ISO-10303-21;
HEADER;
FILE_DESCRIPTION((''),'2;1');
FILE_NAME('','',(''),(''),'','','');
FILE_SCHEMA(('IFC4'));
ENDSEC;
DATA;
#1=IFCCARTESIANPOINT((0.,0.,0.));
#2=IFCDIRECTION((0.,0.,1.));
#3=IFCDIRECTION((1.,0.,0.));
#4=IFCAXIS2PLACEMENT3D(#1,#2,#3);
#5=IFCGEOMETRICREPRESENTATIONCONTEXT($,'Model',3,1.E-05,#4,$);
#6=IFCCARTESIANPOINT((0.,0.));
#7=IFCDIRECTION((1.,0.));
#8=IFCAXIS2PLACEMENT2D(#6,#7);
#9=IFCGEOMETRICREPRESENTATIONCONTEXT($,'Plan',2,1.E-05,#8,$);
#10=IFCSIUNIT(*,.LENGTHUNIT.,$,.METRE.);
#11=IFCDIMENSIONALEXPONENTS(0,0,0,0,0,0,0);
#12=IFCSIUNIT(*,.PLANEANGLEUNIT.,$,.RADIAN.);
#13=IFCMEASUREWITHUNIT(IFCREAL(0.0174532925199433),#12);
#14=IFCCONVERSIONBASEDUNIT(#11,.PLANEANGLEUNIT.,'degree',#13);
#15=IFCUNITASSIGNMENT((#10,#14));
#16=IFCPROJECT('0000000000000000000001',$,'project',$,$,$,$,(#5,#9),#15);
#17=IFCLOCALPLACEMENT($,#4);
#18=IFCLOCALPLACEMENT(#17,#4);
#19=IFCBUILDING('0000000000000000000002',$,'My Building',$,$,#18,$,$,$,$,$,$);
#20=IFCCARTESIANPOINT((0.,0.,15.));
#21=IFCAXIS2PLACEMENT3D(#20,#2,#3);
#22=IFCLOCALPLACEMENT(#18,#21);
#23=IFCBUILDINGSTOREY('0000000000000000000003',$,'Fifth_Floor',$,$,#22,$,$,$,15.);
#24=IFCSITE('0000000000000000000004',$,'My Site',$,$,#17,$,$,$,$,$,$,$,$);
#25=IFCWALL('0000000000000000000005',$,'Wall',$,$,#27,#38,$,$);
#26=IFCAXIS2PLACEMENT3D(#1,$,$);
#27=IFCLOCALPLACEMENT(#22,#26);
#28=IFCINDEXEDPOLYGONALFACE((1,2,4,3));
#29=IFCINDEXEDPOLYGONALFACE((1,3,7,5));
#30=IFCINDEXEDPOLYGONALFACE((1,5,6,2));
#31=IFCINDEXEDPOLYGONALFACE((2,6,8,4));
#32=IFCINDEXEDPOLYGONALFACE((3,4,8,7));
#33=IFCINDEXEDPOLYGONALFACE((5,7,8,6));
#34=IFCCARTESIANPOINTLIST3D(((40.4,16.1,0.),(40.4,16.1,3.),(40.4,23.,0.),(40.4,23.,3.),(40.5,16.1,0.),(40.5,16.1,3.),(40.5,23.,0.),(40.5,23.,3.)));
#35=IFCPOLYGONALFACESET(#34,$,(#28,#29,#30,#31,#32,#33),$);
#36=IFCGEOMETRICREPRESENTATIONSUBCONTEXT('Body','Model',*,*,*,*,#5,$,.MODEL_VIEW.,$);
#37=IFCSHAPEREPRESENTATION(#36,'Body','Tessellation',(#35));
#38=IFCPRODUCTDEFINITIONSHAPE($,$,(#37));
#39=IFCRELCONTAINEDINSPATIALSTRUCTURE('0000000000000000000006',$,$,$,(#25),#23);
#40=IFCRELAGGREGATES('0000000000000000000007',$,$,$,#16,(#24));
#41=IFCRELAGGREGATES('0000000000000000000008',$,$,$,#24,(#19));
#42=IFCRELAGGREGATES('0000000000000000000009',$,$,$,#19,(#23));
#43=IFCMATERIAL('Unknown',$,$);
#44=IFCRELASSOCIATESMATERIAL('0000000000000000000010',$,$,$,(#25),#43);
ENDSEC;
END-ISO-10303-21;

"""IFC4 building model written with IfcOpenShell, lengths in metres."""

from ifc_helpers import new_model, entity, si_unit, converted_unit, frame, frame_2d, origin, origin_with_axes, origin_2d_with_axis, place, context, subcontext, project, spatial, rectangle, extrude, material, element, save


model = new_model("IFC4")

# Units and contexts
model_context = context("Model", 3, precision=1e-05, world=origin_with_axes())
plan_context = context("Plan", 2, precision=1e-05, world=origin_2d_with_axis())
body_context = subcontext(model_context, "Body", "Model", "MODEL_VIEW")
ifc_project = project(units=[si_unit("LENGTHUNIT", "METRE"), converted_unit("PLANEANGLEUNIT", "degree", entity("IfcReal", 0.0174532925199433), si_unit("PLANEANGLEUNIT", "RADIAN"), dimensions=[0, 0, 0, 0, 0, 0, 0])], contexts=[model_context, plan_context])

# Site, building, storey
site_placement = place(None, origin_with_axes())
site = spatial("IfcSite", under=ifc_project, at=site_placement, Name="My Site")
building_placement = place(site_placement, origin_with_axes())
building = spatial("IfcBuilding", under=site, at=building_placement, Name="My Building")
storey_placement = place(building_placement, frame((0.0, 0.0, 15.0), z_axis=(0.0, 0.0, 1.0), x_axis=(1.0, 0.0, 0.0)))
storey = spatial("IfcBuildingStorey", under=building, at=storey_placement, Name="Fifth_Floor", Elevation=15.0)

# Shared definitions
ifc_material = material(Name="Unknown")

# Wall
wall_1_placement = place(storey_placement, origin_with_axes())
element("IfcWall", 1, at=wall_1_placement, inside=storey, material=ifc_material, Name="Wall", context=body_context, shape_type="SweptSolid", body=[
    extrude(rectangle(XDim=0.1, YDim=6.9, at=frame_2d((40.45, 19.55))), origin(), (0.0, 0.0, 1.0), 3.0),
])

save(model, "model.ifc")
